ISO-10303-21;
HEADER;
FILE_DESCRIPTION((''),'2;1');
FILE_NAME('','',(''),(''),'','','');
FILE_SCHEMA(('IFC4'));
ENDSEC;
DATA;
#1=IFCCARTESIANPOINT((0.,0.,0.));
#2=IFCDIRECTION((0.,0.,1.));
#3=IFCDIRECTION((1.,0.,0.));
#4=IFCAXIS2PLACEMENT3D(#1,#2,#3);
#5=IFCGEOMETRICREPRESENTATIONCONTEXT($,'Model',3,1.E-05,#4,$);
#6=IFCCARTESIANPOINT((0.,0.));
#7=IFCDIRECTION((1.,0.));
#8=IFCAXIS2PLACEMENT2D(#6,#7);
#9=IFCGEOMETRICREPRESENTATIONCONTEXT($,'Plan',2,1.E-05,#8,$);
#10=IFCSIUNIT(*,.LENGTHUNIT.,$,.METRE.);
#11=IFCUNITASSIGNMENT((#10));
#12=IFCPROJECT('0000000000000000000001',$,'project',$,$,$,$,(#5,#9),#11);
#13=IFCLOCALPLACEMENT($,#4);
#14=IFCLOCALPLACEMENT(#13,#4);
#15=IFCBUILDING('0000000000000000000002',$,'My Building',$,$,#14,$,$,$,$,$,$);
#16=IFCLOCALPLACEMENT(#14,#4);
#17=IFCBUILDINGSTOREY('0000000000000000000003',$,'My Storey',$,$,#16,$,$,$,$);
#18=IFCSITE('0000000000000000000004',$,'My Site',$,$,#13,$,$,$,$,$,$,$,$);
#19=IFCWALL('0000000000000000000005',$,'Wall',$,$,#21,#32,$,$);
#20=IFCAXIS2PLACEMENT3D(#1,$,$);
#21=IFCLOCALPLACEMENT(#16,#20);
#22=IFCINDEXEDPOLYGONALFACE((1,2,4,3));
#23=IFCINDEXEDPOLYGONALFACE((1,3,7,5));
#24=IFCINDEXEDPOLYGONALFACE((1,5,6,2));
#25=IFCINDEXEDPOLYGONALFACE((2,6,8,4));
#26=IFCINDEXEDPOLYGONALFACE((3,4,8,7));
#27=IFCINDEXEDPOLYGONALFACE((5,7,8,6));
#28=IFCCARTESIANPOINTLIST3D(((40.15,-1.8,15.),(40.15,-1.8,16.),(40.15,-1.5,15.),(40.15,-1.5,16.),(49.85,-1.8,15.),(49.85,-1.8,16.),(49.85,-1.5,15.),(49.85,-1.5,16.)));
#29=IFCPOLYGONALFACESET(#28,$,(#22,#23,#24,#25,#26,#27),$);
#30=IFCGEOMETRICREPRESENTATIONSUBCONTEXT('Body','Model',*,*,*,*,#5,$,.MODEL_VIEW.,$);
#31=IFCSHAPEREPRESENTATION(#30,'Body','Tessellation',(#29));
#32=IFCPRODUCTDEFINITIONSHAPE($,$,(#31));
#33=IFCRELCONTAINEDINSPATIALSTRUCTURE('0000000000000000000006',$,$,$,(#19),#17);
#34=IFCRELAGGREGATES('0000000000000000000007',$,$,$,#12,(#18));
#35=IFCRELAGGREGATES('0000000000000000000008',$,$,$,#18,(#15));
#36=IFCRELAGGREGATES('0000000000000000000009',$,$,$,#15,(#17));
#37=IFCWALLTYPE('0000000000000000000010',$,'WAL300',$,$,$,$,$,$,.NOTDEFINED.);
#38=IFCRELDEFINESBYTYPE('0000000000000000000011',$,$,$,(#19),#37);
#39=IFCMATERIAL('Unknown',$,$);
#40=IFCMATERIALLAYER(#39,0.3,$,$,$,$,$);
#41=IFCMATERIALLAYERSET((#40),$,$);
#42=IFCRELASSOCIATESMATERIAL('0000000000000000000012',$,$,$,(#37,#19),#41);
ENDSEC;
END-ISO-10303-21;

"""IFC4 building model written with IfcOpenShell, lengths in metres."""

from ifc_helpers import new_model, si_unit, frame, origin_with_axes, origin_2d_with_axis, place, context, subcontext, project, spatial, line, indexed_curve, outline, extrude, material, layer, layer_set, layer_usage, type_object, element, save


model = new_model("IFC4")

# Units and contexts
model_context = context("Model", 3, precision=1e-05, world=origin_with_axes())
plan_context = context("Plan", 2, precision=1e-05, world=origin_2d_with_axis())
body_context = subcontext(model_context, "Body", "Model", "MODEL_VIEW")
ifc_project = project(units=[si_unit("LENGTHUNIT", "METRE")], contexts=[model_context, plan_context])

# Site, building, storey
site_placement = place(None, origin_with_axes())
site = spatial("IfcSite", under=ifc_project, at=site_placement, Name="My Site")
building_placement = place(site_placement, origin_with_axes())
building = spatial("IfcBuilding", under=site, at=building_placement, Name="My Building")
storey_placement = place(building_placement, origin_with_axes())
storey = spatial("IfcBuildingStorey", under=building, at=storey_placement, Name="My Storey")

# Shared definitions
ifc_material = material(Name="Unknown")

# Wall
ifc_layer_1 = layer(ifc_material, 0.3)
ifc_layer_set_1 = layer_set([ifc_layer_1])
wall_type = type_object("IfcWallType", Name="WAL300", PredefinedType="NOTDEFINED", material=ifc_layer_set_1)
ifc_layer_usage_1 = layer_usage(ifc_layer_set_1, "AXIS2", "POSITIVE", -0.3)
wall_1_placement = place(storey_placement, frame((40.15, -1.5, 15.0), z_axis=(0.0, 0.0, 1.0), x_axis=(1.0, 0.0, 0.0)))
element("IfcWall", 1, at=wall_1_placement, inside=storey, type_object=wall_type, material=ifc_layer_usage_1, Name="Wall", context=body_context, shape_type="SweptSolid", body=[
    extrude(outline(indexed_curve([(0.0, -0.3), (0.0, 0.0), (9.7, 0.0), (9.7, -0.3)], segments=[line(1, 2, 3, 4, 1)])), origin_with_axes(), (0.0, 0.0, 1.0), 1.0),
])

save(model, "model.ifc")
